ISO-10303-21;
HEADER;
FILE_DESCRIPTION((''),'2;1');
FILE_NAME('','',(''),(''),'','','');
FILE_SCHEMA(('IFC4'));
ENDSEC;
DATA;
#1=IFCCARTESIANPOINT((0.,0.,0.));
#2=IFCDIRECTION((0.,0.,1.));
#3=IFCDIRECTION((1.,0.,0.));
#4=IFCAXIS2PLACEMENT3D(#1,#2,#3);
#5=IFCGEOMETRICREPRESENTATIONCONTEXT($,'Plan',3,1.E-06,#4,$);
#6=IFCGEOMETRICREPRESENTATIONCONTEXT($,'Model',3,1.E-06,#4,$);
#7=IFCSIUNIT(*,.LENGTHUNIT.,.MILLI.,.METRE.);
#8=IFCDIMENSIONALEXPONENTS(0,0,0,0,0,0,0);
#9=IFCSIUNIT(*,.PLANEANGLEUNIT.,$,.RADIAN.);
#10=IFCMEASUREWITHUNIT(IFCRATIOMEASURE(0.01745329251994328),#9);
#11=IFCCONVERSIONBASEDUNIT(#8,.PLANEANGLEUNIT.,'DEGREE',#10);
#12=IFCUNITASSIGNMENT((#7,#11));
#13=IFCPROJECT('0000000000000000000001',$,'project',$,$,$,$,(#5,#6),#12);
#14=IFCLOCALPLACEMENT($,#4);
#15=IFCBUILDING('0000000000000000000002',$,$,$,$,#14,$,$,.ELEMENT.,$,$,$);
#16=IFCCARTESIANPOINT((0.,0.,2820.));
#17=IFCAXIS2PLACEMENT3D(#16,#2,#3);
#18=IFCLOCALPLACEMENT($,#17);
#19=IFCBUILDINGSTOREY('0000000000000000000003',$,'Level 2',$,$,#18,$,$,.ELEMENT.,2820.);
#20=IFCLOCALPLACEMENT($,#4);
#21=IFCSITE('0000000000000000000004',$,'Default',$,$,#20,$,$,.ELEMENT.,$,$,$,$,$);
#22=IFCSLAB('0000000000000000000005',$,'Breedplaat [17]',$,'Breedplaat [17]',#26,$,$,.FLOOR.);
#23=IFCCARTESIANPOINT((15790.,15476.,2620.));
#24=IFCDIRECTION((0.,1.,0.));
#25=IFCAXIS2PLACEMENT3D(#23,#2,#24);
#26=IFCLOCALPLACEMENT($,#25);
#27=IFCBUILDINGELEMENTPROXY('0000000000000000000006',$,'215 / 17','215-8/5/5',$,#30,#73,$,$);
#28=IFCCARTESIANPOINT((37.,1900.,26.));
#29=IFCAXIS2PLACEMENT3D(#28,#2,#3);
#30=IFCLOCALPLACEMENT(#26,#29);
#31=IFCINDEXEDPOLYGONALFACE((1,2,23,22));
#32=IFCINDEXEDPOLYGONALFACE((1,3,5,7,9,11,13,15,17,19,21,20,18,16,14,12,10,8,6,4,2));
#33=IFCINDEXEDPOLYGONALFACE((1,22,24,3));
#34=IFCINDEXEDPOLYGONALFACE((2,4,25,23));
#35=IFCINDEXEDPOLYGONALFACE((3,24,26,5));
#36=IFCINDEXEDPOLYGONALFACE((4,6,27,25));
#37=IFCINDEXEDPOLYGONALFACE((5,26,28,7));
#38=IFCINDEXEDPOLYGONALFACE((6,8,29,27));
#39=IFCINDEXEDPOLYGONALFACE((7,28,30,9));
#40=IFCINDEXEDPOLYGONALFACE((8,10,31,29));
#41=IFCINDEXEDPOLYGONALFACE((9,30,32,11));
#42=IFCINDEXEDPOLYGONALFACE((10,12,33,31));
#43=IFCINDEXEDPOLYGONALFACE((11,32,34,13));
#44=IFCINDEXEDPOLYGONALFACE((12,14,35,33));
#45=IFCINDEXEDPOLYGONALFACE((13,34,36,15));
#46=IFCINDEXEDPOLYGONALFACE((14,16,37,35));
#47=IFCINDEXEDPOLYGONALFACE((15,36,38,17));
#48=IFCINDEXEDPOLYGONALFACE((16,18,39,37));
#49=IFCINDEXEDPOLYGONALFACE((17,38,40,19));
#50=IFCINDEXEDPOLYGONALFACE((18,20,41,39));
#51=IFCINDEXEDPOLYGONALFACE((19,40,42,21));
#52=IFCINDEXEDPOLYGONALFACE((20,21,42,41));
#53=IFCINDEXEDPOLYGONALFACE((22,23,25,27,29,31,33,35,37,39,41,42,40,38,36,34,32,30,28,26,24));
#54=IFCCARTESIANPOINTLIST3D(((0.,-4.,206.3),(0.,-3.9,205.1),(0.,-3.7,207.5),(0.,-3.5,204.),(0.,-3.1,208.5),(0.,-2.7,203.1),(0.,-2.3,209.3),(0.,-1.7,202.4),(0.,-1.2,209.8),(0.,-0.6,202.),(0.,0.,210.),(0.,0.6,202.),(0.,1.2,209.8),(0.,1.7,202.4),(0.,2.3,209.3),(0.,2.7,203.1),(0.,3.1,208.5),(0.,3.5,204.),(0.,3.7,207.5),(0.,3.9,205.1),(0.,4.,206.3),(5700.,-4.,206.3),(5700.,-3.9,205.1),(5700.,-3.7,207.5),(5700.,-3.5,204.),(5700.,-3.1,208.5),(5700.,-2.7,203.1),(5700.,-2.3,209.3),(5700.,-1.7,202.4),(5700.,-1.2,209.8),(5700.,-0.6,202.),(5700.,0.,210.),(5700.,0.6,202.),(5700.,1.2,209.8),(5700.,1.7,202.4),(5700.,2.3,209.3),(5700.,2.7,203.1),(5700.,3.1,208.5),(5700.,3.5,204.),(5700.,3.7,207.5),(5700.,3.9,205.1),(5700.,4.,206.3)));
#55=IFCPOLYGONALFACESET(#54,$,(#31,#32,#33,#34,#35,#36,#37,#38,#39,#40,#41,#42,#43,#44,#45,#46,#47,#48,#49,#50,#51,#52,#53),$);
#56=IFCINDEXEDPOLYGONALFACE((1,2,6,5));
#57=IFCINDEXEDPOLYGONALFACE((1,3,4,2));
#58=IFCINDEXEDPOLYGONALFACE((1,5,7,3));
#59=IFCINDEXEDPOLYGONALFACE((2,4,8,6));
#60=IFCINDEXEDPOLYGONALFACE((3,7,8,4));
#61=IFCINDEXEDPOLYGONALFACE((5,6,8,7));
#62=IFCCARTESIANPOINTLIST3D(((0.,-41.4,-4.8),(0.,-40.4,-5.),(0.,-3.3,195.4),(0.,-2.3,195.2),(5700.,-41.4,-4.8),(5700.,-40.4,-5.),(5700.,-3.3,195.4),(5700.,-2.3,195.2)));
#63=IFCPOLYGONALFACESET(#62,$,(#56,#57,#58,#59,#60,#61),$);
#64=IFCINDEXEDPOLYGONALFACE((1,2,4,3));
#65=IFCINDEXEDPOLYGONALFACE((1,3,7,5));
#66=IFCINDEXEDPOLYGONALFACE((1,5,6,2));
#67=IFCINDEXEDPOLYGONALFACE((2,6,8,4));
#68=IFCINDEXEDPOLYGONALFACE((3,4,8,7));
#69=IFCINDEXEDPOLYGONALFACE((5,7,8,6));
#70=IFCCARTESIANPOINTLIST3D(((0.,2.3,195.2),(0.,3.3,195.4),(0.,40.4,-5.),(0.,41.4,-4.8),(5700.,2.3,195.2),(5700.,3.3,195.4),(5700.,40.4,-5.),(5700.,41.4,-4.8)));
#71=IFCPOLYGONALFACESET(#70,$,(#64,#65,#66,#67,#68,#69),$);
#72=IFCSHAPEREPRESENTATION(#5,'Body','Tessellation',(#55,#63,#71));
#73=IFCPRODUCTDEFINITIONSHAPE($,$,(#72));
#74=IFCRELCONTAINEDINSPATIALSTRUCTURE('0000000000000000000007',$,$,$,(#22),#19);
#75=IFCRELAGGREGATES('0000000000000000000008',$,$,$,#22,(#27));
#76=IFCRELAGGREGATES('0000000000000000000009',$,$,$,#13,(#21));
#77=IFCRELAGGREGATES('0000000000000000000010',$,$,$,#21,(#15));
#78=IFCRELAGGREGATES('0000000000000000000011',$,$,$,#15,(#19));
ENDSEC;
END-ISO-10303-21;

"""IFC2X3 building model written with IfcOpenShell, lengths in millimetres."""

from ifc_helpers import new_model, entity, si_unit, converted_unit, frame, origin_with_axes, origin_2d_with_axis, place, context, project, spatial, rectangle, circle, extrude, element, aggregate, save


model = new_model("IFC2X3")

# Units and contexts
plan_context = context("Plan", 3, precision=1e-06, world=origin_with_axes())
model_context = context("Model", 3, precision=1e-06, world=origin_with_axes())
ifc_project = project(units=[si_unit("LENGTHUNIT", "METRE", prefix="MILLI"), converted_unit("PLANEANGLEUNIT", "DEGREE", entity("IfcRatioMeasure", 0.01745329251994328), si_unit("PLANEANGLEUNIT", "RADIAN"), dimensions=[0, 0, 0, 0, 0, 0, 0])], contexts=[plan_context, model_context])

# Site, building, storey
site_placement = place(None, origin_with_axes())
site = spatial("IfcSite", under=ifc_project, at=site_placement, Name="Default", CompositionType="ELEMENT")
building_placement = place(None, origin_with_axes())
building = spatial("IfcBuilding", under=site, at=building_placement, CompositionType="ELEMENT")
storey_placement = place(None, frame((0.0, 0.0, 2820.0), z_axis=(0.0, 0.0, 1.0), x_axis=(1.0, 0.0, 0.0)))
storey = spatial("IfcBuildingStorey", under=building, at=storey_placement, Name="Level 2", CompositionType="ELEMENT", Elevation=2820.0)

# Slab, building element proxy
slab_1_placement = place(None, frame((15790.0, 15476.0, 2620.0), z_axis=(0.0, 0.0, 1.0), x_axis=(0.0, 1.0, 0.0)))
slab_1 = element("IfcSlab", 1, at=slab_1_placement, inside=storey, Name="Breedplaat [17]", ObjectType="Breedplaat [17]", PredefinedType="FLOOR")
proxy_1_placement = place(slab_1_placement, frame((37.0, 1900.0, 26.0), z_axis=(0.0, 0.0, 1.0), x_axis=(1.0, 0.0, 0.0)))
proxy_1 = element("IfcBuildingElementProxy", 2, at=proxy_1_placement, Name="215 / 17", Description="215-8/5/5", context=plan_context, shape_type="SweptSolid", body=[
    extrude(circle(Radius=4.0, at=origin_2d_with_axis()), frame((0.0, 0.0, 206.0), z_axis=(1.0, 0.0, 0.0), x_axis=(0.0, 0.0, 1.0)), (0.0, 0.0, 1.0), 5700.0),
    extrude(rectangle(XDim=203.8, YDim=1.0, at=origin_2d_with_axis()), frame((0.0, -21.9, 95.2), z_axis=(1.0, 0.0, 0.0), x_axis=(0.0, 0.187112, 0.982339)), (0.0, 0.0, 1.0), 5700.0),
    extrude(rectangle(XDim=203.8, YDim=1.0, at=origin_2d_with_axis()), frame((0.0, 21.9, 95.2), z_axis=(1.0, 0.0, 0.0), x_axis=(0.0, -0.187112, 0.982339)), (0.0, 0.0, 1.0), 5700.0),
])
aggregate(slab_1, [proxy_1])

save(model, "model.ifc")
